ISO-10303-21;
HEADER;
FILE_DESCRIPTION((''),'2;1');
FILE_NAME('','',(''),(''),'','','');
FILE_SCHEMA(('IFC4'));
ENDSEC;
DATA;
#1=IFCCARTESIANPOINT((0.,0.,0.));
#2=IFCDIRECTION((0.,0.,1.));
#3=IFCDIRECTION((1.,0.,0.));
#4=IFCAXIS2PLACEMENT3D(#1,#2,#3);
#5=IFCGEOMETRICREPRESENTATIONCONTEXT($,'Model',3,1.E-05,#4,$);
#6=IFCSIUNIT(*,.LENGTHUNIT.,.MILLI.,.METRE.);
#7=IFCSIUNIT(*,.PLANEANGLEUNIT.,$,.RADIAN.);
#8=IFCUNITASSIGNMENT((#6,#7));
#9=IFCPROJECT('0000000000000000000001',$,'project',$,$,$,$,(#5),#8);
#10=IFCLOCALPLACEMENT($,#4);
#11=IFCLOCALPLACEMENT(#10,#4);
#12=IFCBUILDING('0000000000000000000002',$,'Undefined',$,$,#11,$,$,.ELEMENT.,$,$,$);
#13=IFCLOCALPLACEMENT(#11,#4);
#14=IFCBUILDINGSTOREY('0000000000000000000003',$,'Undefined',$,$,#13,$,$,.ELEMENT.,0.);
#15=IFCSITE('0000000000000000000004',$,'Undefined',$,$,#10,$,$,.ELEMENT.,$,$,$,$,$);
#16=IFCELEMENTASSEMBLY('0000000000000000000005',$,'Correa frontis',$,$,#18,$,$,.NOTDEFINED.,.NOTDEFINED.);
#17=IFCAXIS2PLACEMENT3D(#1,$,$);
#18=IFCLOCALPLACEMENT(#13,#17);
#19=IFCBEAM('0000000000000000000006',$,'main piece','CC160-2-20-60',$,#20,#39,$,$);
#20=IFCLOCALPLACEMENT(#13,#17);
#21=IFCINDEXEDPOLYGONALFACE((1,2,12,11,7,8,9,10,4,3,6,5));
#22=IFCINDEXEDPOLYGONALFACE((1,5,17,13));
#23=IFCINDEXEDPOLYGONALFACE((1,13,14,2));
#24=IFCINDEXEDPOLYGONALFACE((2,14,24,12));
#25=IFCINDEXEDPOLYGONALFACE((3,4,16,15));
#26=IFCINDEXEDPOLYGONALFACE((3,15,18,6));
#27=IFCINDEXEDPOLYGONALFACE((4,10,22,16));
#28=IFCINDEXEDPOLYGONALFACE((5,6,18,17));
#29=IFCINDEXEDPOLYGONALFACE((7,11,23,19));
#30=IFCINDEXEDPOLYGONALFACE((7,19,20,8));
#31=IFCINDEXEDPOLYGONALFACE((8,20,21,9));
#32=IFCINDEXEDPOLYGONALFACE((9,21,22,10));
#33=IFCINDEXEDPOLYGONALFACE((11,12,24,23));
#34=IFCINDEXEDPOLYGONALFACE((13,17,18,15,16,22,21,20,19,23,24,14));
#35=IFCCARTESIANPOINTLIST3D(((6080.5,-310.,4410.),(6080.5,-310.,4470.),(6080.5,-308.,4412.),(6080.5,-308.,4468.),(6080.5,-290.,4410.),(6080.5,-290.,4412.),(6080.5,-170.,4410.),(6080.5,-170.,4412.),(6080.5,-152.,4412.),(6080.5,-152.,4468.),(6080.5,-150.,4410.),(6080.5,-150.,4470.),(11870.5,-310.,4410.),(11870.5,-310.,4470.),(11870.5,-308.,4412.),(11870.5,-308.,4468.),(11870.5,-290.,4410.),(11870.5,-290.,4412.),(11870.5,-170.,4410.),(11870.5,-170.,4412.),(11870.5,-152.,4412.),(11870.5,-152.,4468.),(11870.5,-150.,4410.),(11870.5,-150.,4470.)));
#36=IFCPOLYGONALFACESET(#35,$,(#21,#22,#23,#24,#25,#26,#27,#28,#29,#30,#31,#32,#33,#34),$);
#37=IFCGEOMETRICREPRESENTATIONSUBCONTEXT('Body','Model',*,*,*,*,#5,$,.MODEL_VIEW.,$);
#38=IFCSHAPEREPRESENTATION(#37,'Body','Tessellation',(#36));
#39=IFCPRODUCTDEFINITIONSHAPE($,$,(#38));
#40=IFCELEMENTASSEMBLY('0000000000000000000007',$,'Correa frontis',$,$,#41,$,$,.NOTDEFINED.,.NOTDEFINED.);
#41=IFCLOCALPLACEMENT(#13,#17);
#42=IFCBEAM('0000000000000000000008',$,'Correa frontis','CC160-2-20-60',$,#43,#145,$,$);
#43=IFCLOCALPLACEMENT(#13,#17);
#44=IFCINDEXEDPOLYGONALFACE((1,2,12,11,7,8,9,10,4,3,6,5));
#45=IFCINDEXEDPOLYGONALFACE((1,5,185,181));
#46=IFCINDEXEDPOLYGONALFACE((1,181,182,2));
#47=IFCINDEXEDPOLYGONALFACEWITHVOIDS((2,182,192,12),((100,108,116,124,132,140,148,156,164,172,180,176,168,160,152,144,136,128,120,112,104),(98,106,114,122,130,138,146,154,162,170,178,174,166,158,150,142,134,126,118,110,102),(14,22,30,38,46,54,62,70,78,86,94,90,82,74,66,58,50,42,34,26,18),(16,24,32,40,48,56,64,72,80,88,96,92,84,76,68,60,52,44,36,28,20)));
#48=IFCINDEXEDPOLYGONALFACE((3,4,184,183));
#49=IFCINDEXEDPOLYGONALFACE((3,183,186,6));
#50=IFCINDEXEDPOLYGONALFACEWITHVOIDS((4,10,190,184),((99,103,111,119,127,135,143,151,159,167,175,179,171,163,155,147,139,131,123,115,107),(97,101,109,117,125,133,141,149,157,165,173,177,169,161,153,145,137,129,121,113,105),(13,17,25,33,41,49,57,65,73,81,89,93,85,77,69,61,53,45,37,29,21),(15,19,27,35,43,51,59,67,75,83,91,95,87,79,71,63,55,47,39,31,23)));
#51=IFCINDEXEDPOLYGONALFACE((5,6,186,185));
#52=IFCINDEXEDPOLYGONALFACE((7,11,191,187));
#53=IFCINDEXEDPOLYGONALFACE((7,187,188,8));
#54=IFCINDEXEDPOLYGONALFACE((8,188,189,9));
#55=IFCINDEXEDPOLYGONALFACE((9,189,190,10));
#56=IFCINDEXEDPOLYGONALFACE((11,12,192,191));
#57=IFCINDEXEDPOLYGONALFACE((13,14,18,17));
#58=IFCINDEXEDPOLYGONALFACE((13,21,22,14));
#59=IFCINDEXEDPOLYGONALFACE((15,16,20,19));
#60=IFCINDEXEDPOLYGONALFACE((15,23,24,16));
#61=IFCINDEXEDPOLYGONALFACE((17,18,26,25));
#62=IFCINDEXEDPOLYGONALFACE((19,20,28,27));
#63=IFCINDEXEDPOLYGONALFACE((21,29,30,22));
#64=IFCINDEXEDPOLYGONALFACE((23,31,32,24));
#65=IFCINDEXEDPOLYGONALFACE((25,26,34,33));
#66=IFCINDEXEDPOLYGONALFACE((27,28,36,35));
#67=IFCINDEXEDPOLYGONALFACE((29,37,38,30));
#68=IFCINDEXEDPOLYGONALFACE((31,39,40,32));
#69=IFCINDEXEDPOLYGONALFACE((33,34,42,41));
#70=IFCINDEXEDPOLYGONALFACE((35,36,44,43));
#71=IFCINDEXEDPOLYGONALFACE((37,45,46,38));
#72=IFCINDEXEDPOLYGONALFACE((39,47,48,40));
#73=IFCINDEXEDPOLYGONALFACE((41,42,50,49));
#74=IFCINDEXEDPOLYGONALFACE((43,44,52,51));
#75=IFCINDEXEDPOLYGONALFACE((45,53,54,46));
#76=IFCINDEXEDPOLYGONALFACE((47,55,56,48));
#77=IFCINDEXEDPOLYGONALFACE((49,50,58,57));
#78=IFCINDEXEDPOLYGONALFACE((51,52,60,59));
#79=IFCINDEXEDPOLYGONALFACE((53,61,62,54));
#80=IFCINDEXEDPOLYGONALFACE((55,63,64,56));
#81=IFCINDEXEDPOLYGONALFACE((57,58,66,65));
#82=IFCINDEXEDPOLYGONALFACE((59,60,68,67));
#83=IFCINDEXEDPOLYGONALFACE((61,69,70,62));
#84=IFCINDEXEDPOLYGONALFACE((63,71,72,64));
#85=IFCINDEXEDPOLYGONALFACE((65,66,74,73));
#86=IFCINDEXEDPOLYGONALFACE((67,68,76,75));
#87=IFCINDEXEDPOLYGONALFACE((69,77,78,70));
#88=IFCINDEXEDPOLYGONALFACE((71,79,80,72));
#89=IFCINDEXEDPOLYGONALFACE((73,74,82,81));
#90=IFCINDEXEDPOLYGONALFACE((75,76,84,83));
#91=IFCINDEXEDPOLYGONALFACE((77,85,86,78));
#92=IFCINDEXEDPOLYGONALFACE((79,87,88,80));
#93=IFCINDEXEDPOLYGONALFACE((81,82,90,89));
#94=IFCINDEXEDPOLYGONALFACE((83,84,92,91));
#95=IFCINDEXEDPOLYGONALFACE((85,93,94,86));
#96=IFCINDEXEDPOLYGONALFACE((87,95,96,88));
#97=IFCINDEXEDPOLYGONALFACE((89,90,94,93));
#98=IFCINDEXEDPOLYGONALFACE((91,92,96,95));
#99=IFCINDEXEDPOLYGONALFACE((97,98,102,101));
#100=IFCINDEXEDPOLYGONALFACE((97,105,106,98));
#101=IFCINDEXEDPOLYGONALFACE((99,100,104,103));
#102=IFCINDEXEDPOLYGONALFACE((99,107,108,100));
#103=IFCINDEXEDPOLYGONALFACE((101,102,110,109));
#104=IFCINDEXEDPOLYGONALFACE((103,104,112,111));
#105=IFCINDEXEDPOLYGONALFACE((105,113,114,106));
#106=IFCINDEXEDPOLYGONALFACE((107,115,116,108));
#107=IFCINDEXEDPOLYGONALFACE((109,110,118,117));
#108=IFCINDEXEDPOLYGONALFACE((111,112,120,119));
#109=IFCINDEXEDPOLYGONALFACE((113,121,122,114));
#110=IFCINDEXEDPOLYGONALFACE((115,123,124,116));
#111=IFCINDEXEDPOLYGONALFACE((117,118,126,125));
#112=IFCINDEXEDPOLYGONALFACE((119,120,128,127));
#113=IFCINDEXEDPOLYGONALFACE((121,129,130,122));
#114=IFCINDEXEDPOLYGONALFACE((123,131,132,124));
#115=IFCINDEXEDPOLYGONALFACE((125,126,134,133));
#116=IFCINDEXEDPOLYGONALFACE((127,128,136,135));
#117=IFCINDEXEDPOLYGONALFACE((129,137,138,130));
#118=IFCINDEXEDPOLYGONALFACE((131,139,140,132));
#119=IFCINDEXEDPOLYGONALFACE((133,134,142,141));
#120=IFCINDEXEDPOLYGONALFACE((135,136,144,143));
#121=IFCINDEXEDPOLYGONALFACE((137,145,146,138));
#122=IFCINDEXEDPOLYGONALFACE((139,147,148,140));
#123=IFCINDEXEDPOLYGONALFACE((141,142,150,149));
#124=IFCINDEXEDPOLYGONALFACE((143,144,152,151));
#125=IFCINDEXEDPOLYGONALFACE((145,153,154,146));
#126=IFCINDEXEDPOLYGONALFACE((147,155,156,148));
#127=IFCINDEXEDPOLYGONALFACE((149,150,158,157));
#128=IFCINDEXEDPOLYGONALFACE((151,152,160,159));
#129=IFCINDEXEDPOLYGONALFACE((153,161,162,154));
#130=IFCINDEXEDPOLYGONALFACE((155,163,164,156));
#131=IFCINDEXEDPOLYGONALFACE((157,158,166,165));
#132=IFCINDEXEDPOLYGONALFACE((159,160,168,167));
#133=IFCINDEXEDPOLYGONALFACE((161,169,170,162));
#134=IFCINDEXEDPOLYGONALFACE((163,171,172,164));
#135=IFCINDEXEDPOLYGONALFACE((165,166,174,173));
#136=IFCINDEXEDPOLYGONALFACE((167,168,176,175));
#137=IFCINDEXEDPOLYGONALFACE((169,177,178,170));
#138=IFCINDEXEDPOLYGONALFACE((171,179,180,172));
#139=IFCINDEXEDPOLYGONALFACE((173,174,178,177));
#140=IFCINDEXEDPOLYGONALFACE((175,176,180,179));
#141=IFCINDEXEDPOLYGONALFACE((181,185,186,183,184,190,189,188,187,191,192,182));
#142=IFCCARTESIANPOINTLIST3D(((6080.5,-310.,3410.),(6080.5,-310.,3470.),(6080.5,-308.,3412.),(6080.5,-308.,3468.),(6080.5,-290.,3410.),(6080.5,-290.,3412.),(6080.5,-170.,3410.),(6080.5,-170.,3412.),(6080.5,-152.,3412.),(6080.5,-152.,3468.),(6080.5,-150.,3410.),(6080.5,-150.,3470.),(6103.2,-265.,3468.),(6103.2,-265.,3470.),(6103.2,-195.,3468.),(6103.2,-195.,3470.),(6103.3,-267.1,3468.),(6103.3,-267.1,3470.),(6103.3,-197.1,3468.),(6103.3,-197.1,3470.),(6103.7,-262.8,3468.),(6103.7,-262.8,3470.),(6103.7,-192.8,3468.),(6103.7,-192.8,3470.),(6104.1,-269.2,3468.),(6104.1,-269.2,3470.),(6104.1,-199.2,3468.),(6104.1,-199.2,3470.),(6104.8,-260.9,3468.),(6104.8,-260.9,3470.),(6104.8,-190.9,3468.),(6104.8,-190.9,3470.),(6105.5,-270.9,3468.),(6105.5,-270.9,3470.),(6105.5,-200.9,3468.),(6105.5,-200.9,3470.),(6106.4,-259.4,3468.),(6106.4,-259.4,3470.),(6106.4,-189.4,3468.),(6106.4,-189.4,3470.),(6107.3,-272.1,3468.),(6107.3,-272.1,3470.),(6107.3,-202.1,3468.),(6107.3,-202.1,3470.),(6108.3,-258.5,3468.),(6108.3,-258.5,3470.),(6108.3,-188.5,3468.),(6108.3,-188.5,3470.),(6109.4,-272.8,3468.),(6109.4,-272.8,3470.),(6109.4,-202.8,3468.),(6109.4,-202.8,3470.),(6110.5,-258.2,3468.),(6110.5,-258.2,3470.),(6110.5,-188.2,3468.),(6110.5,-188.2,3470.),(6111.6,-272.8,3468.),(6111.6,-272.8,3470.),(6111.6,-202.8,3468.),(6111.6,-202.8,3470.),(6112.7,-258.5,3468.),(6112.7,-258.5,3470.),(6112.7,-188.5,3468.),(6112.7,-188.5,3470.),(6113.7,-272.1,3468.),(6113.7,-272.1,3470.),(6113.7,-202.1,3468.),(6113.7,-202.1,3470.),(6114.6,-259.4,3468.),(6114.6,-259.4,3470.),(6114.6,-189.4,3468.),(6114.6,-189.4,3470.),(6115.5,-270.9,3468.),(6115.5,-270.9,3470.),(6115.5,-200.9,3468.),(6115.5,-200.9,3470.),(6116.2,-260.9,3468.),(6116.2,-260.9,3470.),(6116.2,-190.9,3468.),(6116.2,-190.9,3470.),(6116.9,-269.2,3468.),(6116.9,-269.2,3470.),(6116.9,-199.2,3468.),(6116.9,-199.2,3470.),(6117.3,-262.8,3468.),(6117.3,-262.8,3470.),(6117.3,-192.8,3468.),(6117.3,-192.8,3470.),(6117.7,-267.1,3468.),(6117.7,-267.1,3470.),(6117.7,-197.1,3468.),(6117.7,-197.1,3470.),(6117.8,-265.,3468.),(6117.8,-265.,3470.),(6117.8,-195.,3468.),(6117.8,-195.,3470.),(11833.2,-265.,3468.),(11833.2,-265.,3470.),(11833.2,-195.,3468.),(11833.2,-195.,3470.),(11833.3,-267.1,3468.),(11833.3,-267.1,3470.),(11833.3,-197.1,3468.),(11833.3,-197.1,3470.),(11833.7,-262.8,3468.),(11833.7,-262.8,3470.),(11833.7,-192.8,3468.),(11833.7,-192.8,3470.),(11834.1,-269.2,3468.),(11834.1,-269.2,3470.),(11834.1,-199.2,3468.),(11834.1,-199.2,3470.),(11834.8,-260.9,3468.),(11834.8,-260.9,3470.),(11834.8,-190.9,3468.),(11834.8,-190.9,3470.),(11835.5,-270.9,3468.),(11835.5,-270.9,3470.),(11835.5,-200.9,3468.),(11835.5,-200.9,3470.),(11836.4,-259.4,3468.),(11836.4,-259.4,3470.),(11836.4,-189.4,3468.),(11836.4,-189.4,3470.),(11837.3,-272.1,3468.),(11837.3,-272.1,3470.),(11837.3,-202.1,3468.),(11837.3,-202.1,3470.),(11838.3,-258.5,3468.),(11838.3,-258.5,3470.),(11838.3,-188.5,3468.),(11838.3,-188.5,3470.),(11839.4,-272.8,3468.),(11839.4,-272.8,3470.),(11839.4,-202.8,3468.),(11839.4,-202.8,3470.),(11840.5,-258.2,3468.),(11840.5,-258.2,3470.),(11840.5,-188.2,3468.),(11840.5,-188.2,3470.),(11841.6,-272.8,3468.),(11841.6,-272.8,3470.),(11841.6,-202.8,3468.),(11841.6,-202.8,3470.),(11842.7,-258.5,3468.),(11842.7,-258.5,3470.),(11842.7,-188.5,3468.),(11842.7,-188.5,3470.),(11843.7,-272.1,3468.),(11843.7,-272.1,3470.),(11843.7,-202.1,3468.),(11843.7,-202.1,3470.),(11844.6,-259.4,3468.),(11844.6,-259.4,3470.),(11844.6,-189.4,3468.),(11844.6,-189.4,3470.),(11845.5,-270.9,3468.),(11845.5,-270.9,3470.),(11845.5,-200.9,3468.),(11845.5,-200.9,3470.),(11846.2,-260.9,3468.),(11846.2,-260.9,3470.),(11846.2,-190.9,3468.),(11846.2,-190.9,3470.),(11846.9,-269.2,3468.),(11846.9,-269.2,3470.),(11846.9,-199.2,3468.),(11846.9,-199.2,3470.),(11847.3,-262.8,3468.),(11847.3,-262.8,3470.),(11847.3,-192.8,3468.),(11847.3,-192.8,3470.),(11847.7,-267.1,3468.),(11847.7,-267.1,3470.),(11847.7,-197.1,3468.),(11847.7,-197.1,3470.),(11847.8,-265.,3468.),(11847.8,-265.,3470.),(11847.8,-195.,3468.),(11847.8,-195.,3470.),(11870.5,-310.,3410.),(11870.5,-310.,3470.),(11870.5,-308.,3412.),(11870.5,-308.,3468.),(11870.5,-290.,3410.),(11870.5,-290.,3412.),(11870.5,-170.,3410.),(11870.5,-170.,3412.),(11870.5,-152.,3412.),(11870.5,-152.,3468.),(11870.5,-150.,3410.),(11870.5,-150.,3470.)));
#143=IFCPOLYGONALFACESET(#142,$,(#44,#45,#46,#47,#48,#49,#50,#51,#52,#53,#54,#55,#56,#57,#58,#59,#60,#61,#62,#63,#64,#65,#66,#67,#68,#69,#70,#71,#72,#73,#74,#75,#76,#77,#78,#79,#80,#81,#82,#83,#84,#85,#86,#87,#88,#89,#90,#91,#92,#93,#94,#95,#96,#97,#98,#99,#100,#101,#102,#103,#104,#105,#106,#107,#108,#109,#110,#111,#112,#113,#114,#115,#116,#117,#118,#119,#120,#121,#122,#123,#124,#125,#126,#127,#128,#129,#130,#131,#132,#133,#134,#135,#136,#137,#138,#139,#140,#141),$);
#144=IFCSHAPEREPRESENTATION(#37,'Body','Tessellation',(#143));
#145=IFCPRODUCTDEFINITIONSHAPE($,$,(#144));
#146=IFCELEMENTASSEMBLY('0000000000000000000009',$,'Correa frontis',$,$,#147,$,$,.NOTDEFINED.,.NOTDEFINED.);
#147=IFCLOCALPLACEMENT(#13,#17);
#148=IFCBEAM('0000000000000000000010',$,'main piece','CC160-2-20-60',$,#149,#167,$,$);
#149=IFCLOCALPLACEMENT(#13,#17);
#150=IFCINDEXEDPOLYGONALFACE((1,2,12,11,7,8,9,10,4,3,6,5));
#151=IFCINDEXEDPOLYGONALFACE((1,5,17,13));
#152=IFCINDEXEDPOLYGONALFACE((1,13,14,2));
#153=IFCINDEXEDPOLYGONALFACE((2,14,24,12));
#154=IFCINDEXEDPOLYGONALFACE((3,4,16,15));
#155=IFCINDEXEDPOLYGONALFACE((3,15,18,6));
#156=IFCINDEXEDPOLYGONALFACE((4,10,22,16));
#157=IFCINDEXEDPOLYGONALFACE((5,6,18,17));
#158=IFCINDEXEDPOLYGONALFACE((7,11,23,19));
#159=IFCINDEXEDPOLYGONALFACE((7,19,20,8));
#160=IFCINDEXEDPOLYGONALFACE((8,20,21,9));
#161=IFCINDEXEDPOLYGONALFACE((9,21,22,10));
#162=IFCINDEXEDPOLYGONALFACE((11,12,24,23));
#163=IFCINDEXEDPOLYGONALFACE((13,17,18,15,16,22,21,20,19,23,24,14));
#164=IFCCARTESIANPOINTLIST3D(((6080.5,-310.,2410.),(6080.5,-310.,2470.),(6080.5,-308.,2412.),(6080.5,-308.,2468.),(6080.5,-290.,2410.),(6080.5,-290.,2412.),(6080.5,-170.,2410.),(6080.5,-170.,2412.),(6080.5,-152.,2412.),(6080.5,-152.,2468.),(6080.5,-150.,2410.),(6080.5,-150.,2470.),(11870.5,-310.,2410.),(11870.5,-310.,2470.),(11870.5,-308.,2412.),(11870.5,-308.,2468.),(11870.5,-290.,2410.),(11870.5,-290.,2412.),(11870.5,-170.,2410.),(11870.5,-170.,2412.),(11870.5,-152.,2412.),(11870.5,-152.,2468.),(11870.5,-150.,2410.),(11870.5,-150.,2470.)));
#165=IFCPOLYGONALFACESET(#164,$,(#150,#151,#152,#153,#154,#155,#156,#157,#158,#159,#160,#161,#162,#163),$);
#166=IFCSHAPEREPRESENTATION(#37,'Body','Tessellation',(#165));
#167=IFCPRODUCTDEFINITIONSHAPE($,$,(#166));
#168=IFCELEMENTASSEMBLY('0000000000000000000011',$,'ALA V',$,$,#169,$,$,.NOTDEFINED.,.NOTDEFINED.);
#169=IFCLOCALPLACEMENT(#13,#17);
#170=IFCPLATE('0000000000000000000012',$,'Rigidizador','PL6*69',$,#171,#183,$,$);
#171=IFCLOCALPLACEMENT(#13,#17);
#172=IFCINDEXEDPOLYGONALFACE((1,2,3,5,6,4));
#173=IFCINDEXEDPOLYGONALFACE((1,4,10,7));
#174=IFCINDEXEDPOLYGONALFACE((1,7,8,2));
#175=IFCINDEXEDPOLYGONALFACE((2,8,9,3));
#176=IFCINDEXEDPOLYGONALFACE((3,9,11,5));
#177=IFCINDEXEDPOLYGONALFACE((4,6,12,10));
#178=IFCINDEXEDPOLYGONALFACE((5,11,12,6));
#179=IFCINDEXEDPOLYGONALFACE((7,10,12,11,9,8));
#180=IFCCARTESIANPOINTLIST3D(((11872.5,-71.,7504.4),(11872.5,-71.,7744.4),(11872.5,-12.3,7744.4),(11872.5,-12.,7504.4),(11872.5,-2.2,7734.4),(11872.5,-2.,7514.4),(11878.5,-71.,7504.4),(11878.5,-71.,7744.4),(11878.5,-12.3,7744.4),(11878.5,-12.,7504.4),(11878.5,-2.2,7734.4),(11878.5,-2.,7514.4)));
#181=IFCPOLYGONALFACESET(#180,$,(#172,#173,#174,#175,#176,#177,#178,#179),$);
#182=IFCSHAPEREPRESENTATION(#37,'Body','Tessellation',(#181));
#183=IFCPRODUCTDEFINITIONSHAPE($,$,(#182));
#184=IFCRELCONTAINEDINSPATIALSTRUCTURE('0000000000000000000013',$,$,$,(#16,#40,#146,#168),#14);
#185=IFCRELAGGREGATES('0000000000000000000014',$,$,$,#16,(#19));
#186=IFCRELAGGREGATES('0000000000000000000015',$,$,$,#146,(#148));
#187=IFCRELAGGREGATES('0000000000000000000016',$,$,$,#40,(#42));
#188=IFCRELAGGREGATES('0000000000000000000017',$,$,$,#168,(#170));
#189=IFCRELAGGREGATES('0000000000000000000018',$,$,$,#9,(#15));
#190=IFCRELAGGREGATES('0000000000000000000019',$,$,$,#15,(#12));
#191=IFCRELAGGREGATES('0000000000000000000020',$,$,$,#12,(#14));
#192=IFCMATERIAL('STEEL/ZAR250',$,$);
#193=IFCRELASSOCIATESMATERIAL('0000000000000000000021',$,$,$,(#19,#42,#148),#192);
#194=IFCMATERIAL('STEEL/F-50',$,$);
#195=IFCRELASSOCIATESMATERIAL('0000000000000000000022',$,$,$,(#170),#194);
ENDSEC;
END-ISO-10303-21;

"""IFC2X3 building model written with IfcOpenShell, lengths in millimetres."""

from ifc_helpers import new_model, si_unit, frame, origin_with_axes, origin_2d_with_axis, place, context, subcontext, project, spatial, polyline, circle, c_section, outline, extrude, source, transform, mapped, material, element, aggregate, save


model = new_model("IFC2X3")

# Units and contexts
model_context = context("Model", 3, precision=1e-05, world=origin_with_axes())
body_context = subcontext(model_context, "Body", "Model", "MODEL_VIEW")
ifc_project = project(units=[si_unit("LENGTHUNIT", "METRE", prefix="MILLI"), si_unit("PLANEANGLEUNIT", "RADIAN")], contexts=[model_context])

# Site, building, storey
site_placement = place(None, origin_with_axes())
site = spatial("IfcSite", under=ifc_project, at=site_placement, Name="Undefined", CompositionType="ELEMENT")
building_placement = place(site_placement, origin_with_axes())
building = spatial("IfcBuilding", under=site, at=building_placement, Name="Undefined", CompositionType="ELEMENT")
storey_placement = place(building_placement, origin_with_axes())
storey = spatial("IfcBuildingStorey", under=building, at=storey_placement, Name="Undefined", CompositionType="ELEMENT", Elevation=0.0)

# Shared definitions
ifc_material_1 = material(Name="STEEL/F-50")

# Shared definitions
ifc_material_2 = material(Name="STEEL/ZAR250")

# Element assembly, beam
assembly_1_placement = place(storey_placement, origin_with_axes())
assembly_1 = element("IfcElementAssembly", 1, at=assembly_1_placement, inside=storey, Name="Correa frontis", AssemblyPlace="NOTDEFINED", PredefinedType="NOTDEFINED")
beam_1_placement = place(assembly_1_placement, frame((11870.5, -230.0, 4440.0), z_axis=(0.0, 1.0, 0.0), x_axis=(-1.0, 0.0, 0.0)))
beam_1 = element("IfcBeam", 2, at=beam_1_placement, material=ifc_material_2, Name="main piece", Description="CC160-2-20-60", context=body_context, shape_type="SweptSolid", body=[
    extrude(c_section(Depth=160.0, Width=60.0, WallThickness=2.0, Girth=20.0, at=origin_2d_with_axis()), frame((5790.0, 0.0, 0.0), z_axis=(-1.0, 0.0, 0.0), x_axis=(0.0, -1.0, 0.0)), (0.0, 0.0, 1.0), 5790.0),
])
aggregate(assembly_1, [beam_1])

# Element assembly, beam, openings
assembly_2_placement = place(storey_placement, origin_with_axes())
assembly_2 = element("IfcElementAssembly", 3, at=assembly_2_placement, inside=storey, Name="Correa frontis", AssemblyPlace="NOTDEFINED", PredefinedType="NOTDEFINED")
beam_2_placement = place(assembly_2_placement, frame((11870.5, -230.0, 3440.0), z_axis=(0.0, 1.0, 0.0), x_axis=(-1.0, 0.0, 0.0)))
beam_2 = element("IfcBeam", 4, at=beam_2_placement, material=ifc_material_2, Name="Correa frontis", Description="CC160-2-20-60", context=body_context, shape_type="SweptSolid", body=[
    extrude(c_section(Depth=160.0, Width=60.0, WallThickness=2.0, Girth=20.0, at=origin_2d_with_axis()), frame((5790.0, 0.0, 0.0), z_axis=(-1.0, 0.0, 0.0), x_axis=(0.0, -1.0, 0.0)), (0.0, 0.0, 1.0), 5790.0),
])
shared_shape_1 = source(origin_with_axes(), body_context, "Body", "SweptSolid", [
    extrude(circle(Radius=7.3, at=origin_2d_with_axis()), frame((0.0, -0.1, 0.0), z_axis=(0.0, 1.0, 0.0), x_axis=(1.0, 0.0, 0.0)), (0.0, 0.0, 1.0), 2.2),
])
opening_1_placement = place(assembly_2_placement, frame((11840.5, -265.5, 3470.0), z_axis=(-1.0, 0.0, 0.0), x_axis=(0.0, 1.0, 0.0)))
element("IfcOpeningElement", 5, at=opening_1_placement, cuts=beam_2, ObjectType="Opening", context=body_context, shape_type="MappedRepresentation", body=[
    mapped(shared_shape_1, transform((0.0, 0.0, 0.0))),
    mapped(shared_shape_1, transform((70.0, 0.0, 0.0))),
])
opening_2_placement = place(assembly_2_placement, frame((6110.5, -265.5, 3470.0), z_axis=(-1.0, 0.0, 0.0), x_axis=(0.0, 1.0, 0.0)))
element("IfcOpeningElement", 6, at=opening_2_placement, cuts=beam_2, ObjectType="Opening", context=body_context, shape_type="MappedRepresentation", body=[
    mapped(shared_shape_1, transform((0.0, 0.0, 0.0))),
    mapped(shared_shape_1, transform((70.0, 0.0, 0.0))),
])

# Element assembly, beam
assembly_3_placement = place(storey_placement, origin_with_axes())
assembly_3 = element("IfcElementAssembly", 7, at=assembly_3_placement, inside=storey, Name="Correa frontis", AssemblyPlace="NOTDEFINED", PredefinedType="NOTDEFINED")
beam_3_placement = place(assembly_3_placement, frame((11870.5, -230.0, 2440.0), z_axis=(0.0, 1.0, 0.0), x_axis=(-1.0, 0.0, 0.0)))
beam_3 = element("IfcBeam", 8, at=beam_3_placement, material=ifc_material_2, Name="main piece", Description="CC160-2-20-60", context=body_context, shape_type="SweptSolid", body=[
    extrude(c_section(Depth=160.0, Width=60.0, WallThickness=2.0, Girth=20.0, at=origin_2d_with_axis()), frame((5790.0, 0.0, 0.0), z_axis=(-1.0, 0.0, 0.0), x_axis=(0.0, -1.0, 0.0)), (0.0, 0.0, 1.0), 5790.0),
])
aggregate(assembly_3, [beam_3])

# Element assembly, plate
assembly_4_placement = place(storey_placement, origin_with_axes())
assembly_4 = element("IfcElementAssembly", 9, at=assembly_4_placement, inside=storey, Name="ALA V", AssemblyPlace="NOTDEFINED", PredefinedType="NOTDEFINED")
plate_placement = place(assembly_4_placement, frame((11875.5, -2.0, 7504.4), z_axis=(-1.0, 0.0, 0.000014), x_axis=(0.0, -1.0, 0.0)))
plate = element("IfcPlate", 10, at=plate_placement, material=ifc_material_1, Name="Rigidizador", Description="PL6*69", context=body_context, shape_type="SweptSolid", body=[
    extrude(outline(polyline([(0.0, 10.0), (10.0, 0.0), (69.0, 0.0), (69.0, 240.0), (10.3, 240.0), (0.2, 230.0), (0.0, 10.0)])), frame((0.0, 0.0, -3.0), z_axis=(0.0, 0.0, 1.0), x_axis=(1.0, 0.0, 0.0)), (0.0, 0.0, 1.0), 6.0),
])

aggregate(assembly_2, [beam_2])

aggregate(assembly_4, [plate])

save(model, "model.ifc")
